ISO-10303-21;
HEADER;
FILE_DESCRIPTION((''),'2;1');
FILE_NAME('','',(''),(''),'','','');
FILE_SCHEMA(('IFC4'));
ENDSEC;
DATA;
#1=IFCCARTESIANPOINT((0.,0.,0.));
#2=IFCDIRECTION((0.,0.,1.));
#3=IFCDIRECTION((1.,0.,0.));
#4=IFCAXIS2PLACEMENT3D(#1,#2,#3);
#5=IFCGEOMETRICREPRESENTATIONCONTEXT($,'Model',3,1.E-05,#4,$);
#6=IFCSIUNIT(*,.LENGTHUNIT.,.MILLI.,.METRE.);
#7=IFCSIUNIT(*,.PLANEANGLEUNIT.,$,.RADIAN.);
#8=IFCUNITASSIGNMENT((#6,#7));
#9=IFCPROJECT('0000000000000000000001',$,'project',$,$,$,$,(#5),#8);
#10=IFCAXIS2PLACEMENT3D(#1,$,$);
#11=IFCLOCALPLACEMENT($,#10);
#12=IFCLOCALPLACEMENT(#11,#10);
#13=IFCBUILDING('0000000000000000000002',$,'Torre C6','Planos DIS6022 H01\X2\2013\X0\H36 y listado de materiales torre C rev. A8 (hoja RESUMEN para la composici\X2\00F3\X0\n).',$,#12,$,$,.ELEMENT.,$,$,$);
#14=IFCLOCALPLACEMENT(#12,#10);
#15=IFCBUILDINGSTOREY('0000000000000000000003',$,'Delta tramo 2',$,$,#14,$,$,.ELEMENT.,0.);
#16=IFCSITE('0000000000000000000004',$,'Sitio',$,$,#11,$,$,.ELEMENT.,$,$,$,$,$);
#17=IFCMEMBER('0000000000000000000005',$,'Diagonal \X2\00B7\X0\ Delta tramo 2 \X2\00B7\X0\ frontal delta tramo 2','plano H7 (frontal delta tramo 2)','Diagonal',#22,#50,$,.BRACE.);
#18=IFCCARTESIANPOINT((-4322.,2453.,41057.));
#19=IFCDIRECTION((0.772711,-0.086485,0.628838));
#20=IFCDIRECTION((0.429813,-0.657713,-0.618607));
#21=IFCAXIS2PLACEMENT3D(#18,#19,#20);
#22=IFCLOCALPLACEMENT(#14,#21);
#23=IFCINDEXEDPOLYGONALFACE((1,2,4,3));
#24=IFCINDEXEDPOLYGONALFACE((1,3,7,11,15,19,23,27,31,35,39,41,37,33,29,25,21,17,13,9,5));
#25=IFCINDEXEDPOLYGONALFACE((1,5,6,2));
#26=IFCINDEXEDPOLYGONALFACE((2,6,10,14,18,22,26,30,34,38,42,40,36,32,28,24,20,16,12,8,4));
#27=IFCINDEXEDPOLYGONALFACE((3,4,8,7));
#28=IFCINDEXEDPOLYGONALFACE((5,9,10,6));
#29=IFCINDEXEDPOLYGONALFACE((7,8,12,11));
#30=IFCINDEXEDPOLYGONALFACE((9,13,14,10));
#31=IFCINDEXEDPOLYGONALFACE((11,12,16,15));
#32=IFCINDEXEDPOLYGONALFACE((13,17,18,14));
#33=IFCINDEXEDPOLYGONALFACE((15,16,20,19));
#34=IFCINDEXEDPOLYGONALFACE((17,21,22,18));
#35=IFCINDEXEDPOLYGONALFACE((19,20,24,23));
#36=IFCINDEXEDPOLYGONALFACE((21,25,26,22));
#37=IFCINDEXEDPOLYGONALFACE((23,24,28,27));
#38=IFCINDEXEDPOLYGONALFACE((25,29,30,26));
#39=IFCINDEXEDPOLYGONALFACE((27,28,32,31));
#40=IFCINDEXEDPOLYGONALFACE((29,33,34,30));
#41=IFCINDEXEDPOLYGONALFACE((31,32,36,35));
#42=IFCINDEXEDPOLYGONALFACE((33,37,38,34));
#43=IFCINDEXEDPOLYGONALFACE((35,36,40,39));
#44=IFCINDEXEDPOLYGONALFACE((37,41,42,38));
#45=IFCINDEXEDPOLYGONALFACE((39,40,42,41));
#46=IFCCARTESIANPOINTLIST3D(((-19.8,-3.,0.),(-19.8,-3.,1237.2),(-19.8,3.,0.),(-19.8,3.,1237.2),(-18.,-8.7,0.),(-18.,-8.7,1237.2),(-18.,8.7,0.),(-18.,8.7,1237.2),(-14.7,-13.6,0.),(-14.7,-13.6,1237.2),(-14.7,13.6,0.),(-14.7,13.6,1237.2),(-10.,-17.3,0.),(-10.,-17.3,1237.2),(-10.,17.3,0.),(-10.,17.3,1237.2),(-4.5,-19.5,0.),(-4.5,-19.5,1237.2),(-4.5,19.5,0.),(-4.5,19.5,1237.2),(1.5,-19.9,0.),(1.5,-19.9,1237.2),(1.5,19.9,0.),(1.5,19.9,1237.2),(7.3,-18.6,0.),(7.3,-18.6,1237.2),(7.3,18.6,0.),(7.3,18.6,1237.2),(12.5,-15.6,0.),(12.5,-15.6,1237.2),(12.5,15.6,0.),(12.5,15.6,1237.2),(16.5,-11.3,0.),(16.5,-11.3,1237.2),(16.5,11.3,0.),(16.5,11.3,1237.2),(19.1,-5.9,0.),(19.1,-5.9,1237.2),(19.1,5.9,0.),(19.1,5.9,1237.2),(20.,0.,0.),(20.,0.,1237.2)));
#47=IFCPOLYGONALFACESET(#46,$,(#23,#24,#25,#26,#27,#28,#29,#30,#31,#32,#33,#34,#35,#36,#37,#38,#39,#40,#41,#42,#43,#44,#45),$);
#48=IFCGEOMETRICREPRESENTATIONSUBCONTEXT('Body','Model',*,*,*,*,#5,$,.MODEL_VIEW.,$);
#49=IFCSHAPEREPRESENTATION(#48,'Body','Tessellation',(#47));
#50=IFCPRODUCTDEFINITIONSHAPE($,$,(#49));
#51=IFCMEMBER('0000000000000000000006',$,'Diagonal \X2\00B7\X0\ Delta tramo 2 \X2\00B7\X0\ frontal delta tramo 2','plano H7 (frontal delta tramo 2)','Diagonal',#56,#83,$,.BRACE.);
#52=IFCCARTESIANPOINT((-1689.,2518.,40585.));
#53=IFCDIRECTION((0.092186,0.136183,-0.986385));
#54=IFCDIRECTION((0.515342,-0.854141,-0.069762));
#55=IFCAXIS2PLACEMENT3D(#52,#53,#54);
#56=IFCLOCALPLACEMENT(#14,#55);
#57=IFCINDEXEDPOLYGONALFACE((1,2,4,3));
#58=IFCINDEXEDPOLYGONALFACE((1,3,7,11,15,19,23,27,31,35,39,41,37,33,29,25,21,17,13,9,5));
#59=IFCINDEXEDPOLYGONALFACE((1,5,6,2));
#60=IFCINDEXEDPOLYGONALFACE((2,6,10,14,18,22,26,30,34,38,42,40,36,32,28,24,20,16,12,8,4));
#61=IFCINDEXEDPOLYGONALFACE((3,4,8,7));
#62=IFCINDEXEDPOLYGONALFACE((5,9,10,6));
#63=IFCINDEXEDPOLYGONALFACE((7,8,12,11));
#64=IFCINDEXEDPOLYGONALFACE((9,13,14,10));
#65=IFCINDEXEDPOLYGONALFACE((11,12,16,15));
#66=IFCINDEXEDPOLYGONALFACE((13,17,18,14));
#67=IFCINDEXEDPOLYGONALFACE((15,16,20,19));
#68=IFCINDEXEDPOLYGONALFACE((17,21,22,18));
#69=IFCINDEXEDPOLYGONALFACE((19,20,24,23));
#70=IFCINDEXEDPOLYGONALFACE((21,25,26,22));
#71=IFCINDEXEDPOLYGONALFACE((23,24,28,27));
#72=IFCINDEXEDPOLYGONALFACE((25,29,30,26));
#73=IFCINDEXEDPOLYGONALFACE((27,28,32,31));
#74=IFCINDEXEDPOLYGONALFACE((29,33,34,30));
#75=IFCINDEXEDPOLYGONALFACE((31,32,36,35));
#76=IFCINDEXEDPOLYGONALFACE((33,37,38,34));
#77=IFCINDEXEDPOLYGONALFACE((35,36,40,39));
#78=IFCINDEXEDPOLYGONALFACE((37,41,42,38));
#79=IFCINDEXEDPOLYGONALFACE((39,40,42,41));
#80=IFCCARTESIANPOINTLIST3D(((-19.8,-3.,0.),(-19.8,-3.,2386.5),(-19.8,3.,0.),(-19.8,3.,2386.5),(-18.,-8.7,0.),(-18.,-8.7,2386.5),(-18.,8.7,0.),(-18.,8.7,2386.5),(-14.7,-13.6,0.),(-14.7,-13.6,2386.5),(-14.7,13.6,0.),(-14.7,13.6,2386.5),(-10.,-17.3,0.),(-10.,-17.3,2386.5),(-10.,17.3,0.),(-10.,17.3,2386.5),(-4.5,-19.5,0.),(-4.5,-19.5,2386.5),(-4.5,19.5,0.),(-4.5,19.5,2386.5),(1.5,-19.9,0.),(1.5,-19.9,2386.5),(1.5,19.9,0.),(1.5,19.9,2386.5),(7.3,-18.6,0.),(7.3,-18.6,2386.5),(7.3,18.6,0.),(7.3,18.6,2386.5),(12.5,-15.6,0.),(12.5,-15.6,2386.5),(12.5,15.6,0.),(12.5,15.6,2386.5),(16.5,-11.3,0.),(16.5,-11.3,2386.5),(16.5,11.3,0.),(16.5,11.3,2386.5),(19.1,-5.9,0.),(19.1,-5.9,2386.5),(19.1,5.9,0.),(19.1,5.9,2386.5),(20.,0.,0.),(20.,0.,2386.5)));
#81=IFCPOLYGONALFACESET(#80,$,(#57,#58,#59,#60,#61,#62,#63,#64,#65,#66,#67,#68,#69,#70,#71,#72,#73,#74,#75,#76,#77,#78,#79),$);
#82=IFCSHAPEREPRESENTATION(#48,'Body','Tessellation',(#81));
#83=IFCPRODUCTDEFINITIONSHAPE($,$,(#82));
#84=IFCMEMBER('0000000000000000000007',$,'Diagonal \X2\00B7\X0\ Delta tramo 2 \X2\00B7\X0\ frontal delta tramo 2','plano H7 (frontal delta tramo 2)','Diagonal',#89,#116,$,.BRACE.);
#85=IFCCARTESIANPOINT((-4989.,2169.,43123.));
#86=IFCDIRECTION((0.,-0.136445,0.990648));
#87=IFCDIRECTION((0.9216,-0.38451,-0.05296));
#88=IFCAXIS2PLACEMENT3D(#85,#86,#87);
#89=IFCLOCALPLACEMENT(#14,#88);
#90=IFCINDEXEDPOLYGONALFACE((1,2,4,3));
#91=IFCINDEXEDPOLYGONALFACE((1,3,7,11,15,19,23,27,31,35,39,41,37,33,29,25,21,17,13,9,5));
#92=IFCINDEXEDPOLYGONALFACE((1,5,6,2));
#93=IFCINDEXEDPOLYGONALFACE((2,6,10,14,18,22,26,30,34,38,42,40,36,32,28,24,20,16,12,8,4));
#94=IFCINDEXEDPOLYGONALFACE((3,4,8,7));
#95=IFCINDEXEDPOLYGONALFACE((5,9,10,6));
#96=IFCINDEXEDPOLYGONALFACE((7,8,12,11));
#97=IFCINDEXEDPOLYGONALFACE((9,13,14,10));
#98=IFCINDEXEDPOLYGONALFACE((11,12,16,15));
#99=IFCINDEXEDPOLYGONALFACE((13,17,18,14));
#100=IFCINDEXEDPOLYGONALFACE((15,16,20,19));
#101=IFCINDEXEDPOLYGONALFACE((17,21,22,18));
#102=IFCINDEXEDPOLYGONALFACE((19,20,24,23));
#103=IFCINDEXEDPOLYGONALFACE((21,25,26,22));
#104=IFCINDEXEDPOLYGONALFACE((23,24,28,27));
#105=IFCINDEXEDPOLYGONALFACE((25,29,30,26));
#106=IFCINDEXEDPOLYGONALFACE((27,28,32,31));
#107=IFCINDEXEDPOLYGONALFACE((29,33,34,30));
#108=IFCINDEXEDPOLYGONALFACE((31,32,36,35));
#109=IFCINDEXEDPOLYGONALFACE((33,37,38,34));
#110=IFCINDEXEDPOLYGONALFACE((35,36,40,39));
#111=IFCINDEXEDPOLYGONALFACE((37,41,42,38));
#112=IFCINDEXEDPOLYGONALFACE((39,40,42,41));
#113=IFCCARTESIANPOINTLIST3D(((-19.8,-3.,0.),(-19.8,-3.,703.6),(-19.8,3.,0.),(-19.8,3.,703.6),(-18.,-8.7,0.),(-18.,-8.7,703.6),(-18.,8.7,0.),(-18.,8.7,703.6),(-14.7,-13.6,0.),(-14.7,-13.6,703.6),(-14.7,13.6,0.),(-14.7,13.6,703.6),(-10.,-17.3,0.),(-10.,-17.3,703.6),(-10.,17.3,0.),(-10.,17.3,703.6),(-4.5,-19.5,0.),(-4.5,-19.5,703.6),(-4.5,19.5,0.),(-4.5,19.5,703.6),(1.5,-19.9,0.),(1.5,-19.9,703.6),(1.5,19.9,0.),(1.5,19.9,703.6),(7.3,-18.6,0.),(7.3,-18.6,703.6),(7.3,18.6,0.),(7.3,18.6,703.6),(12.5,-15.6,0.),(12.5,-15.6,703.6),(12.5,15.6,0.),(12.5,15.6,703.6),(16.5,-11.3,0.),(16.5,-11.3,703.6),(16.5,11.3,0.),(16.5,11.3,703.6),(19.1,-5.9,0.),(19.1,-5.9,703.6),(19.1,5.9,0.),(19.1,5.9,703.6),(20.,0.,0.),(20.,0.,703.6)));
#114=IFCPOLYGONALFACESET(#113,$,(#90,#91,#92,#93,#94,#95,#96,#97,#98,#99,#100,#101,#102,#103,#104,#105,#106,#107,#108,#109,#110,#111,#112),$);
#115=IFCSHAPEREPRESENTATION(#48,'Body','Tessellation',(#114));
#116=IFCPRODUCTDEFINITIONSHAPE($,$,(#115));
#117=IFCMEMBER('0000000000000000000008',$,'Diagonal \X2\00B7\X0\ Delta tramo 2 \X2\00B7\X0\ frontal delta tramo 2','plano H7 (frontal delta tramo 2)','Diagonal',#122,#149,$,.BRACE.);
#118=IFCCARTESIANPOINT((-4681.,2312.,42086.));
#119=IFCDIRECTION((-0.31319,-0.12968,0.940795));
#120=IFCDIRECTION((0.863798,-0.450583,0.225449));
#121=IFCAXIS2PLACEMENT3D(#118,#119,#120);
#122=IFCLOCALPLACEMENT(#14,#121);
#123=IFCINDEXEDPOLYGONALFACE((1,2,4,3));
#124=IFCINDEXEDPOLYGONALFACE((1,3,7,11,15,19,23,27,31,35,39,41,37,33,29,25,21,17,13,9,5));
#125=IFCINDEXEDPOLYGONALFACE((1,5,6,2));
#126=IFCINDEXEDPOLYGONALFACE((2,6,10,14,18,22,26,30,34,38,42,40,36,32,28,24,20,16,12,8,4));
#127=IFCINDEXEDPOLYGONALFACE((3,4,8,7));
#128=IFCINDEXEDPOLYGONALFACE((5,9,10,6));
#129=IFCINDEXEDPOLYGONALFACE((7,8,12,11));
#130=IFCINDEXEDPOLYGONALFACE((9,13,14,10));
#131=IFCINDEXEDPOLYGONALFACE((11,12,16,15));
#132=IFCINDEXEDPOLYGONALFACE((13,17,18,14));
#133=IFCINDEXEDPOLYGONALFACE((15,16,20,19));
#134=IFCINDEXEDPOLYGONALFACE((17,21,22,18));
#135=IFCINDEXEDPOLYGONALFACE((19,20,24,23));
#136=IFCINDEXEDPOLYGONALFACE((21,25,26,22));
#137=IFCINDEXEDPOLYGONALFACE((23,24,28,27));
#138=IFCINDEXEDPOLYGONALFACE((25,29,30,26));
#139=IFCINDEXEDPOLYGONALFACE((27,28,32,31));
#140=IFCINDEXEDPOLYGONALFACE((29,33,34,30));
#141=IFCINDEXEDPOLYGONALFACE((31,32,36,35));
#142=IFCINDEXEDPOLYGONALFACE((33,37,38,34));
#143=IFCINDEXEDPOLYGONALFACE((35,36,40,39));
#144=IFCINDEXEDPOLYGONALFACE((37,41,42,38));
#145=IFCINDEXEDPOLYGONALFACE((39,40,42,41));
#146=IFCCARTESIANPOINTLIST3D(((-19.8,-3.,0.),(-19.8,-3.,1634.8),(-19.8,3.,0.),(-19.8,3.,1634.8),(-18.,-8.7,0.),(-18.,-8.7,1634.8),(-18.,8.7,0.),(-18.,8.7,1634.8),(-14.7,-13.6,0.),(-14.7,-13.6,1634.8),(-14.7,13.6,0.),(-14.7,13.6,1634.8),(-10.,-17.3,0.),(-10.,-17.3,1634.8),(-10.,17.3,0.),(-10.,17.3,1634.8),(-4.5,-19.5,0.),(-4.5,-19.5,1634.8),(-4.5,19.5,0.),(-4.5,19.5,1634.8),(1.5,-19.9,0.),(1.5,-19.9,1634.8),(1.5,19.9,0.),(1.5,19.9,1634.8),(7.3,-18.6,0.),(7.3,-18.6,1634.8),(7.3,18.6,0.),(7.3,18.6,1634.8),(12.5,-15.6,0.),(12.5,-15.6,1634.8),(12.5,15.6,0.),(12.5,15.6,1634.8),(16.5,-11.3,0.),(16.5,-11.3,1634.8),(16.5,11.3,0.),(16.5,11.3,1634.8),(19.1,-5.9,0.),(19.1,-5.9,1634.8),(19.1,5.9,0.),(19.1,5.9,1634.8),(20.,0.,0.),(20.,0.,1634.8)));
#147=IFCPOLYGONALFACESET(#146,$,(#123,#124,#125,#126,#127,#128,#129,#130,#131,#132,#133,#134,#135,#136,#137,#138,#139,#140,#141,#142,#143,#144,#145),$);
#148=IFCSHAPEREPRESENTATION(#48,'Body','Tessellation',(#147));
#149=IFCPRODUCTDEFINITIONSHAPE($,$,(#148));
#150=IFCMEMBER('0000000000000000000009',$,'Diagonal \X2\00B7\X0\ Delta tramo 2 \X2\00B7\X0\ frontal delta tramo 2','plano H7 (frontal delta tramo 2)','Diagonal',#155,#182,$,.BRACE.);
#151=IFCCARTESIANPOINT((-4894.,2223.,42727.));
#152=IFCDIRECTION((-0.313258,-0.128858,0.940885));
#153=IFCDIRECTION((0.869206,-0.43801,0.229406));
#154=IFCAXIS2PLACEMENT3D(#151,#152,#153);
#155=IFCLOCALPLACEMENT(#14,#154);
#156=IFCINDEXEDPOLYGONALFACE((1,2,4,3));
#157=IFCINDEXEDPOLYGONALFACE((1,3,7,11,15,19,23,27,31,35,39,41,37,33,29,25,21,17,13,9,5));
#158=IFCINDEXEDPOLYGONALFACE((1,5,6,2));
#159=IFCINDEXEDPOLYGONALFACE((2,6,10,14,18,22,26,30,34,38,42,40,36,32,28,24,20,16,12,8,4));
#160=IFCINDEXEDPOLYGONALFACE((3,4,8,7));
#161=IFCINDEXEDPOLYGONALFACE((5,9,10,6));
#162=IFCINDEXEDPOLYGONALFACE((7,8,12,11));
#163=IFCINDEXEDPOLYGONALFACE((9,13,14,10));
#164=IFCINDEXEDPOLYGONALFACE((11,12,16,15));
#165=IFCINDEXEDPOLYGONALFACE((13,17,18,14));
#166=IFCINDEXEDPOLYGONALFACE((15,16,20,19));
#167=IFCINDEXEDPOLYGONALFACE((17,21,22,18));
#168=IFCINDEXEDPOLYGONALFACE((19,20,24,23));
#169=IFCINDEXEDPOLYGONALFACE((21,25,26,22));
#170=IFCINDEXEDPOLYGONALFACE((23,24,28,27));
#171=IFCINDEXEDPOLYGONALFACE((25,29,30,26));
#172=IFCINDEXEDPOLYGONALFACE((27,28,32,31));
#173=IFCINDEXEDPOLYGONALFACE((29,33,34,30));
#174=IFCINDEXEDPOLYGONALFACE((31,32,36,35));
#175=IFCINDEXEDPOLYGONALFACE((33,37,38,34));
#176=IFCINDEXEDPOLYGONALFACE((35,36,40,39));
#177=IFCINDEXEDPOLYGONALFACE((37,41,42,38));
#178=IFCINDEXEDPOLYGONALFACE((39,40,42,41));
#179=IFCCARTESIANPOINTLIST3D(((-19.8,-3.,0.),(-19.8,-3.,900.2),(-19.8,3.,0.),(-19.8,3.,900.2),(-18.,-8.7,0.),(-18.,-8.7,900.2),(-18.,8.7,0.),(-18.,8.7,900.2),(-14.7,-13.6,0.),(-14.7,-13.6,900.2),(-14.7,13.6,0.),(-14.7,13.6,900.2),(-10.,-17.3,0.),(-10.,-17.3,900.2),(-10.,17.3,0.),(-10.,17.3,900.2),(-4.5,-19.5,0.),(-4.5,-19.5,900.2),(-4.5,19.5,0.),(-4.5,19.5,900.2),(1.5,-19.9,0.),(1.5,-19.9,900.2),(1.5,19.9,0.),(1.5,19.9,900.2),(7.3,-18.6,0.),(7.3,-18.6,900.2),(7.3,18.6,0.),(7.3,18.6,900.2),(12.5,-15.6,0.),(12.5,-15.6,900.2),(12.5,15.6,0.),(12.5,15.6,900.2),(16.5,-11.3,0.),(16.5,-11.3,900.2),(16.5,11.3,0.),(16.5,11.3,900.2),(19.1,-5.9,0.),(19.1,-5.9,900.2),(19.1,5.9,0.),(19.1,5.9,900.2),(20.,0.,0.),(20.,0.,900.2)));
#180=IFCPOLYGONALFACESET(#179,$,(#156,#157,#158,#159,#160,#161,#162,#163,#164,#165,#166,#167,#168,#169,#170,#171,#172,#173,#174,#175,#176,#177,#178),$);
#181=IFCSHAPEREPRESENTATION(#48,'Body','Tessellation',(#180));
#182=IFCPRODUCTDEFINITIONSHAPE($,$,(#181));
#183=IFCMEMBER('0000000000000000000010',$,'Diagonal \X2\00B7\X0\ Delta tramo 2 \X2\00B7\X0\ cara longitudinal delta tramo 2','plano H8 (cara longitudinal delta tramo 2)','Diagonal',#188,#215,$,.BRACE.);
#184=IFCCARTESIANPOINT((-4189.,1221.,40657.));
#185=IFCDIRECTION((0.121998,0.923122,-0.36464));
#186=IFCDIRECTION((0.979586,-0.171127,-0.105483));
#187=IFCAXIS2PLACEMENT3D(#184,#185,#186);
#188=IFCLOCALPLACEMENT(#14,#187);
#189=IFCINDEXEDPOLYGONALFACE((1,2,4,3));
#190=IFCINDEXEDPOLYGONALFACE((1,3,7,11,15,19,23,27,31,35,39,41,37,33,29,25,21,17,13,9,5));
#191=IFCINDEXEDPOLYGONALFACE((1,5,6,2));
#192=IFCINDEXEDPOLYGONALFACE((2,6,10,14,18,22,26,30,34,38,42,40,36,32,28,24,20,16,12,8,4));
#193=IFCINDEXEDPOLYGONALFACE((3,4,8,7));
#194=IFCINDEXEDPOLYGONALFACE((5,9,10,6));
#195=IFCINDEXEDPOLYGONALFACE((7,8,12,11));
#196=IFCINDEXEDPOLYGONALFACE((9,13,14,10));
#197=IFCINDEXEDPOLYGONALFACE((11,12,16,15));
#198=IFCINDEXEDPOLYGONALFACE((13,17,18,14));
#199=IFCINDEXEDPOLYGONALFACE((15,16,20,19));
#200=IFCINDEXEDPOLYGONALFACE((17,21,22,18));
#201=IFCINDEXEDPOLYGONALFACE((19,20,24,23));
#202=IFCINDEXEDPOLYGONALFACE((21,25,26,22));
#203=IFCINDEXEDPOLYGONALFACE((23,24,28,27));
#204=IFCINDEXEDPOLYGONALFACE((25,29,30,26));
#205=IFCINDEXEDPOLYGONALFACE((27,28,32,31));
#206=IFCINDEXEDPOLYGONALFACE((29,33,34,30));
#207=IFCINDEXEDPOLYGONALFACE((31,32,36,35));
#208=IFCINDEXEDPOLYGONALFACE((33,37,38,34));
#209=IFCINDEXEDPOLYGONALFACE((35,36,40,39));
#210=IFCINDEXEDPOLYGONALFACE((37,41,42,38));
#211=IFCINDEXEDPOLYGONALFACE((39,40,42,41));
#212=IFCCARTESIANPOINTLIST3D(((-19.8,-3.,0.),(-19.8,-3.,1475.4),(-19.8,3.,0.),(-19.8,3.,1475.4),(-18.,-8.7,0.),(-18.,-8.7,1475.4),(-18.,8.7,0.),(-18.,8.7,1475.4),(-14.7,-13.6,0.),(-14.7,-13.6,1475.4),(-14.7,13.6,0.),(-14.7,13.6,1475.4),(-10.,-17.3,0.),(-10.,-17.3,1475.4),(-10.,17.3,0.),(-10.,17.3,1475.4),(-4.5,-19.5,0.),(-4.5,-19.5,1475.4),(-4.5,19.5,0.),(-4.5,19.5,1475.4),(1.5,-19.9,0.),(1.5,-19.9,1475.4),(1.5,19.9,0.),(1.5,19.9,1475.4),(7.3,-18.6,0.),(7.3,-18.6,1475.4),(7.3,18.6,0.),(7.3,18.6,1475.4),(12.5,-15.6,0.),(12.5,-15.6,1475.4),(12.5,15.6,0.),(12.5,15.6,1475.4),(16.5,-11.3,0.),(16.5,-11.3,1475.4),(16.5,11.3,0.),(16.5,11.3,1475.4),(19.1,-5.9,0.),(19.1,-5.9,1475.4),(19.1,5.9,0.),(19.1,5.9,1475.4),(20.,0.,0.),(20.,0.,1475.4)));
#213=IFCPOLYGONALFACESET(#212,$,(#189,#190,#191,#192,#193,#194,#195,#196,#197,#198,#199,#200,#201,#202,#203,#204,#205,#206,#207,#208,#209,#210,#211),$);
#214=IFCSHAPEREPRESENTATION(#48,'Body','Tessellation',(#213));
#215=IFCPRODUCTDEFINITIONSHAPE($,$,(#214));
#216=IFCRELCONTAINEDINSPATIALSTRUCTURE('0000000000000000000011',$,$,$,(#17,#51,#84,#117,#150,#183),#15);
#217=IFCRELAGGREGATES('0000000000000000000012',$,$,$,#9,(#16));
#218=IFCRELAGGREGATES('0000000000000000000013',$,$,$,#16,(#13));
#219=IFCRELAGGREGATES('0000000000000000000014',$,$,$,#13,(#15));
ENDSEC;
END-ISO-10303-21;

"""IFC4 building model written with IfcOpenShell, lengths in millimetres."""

from ifc_helpers import new_model, si_unit, frame, origin, origin_with_axes, place, context, subcontext, project, spatial, circle, extrude, element, save


model = new_model("IFC4")

# Units and contexts
model_context = context("Model", 3, precision=1e-05, world=origin_with_axes())
body_context = subcontext(model_context, "Body", "Model", "MODEL_VIEW")
ifc_project = project(units=[si_unit("LENGTHUNIT", "METRE", prefix="MILLI"), si_unit("PLANEANGLEUNIT", "RADIAN")], contexts=[model_context])

# Site, building, storey
site_placement = place(None, origin())
site = spatial("IfcSite", under=ifc_project, at=site_placement, Name="Sitio", CompositionType="ELEMENT")
building_placement = place(site_placement, origin())
building = spatial("IfcBuilding", under=site, at=building_placement, Name="Torre C6", Description="Planos DIS6022 H01–H36 y listado de materiales torre C rev. A8 (hoja RESUMEN para la composición).", CompositionType="ELEMENT")
storey_placement = place(building_placement, origin())
storey = spatial("IfcBuildingStorey", under=building, at=storey_placement, Name="Delta tramo 2", CompositionType="ELEMENT", Elevation=0.0)

# Members
member_1_placement = place(storey_placement, frame((-4322.0, 2453.0, 41057.0), z_axis=(0.772711, -0.086485, 0.628838), x_axis=(0.429813, -0.657713, -0.618607)))
element("IfcMember", 1, at=member_1_placement, inside=storey, Name="Diagonal · Delta tramo 2 · frontal delta tramo 2", Description="plano H7 (frontal delta tramo 2)", ObjectType="Diagonal", PredefinedType="BRACE", context=body_context, shape_type="SweptSolid", body=[
    extrude(circle(Radius=20.0), None, (0.0, 0.0, 1.0), 1237.2),
])
member_2_placement = place(storey_placement, frame((-1689.0, 2518.0, 40585.0), z_axis=(0.092186, 0.136183, -0.986385), x_axis=(0.515342, -0.854141, -0.069762)))
element("IfcMember", 2, at=member_2_placement, inside=storey, Name="Diagonal · Delta tramo 2 · frontal delta tramo 2", Description="plano H7 (frontal delta tramo 2)", ObjectType="Diagonal", PredefinedType="BRACE", context=body_context, shape_type="SweptSolid", body=[
    extrude(circle(Radius=20.0), None, (0.0, 0.0, 1.0), 2386.5),
])
member_3_placement = place(storey_placement, frame((-4989.0, 2169.0, 43123.0), z_axis=(0.0, -0.136445, 0.990648), x_axis=(0.9216, -0.38451, -0.05296)))
element("IfcMember", 3, at=member_3_placement, inside=storey, Name="Diagonal · Delta tramo 2 · frontal delta tramo 2", Description="plano H7 (frontal delta tramo 2)", ObjectType="Diagonal", PredefinedType="BRACE", context=body_context, shape_type="SweptSolid", body=[
    extrude(circle(Radius=20.0), None, (0.0, 0.0, 1.0), 703.6),
])
member_4_placement = place(storey_placement, frame((-4681.0, 2312.0, 42086.0), z_axis=(-0.31319, -0.12968, 0.940795), x_axis=(0.863798, -0.450583, 0.225449)))
element("IfcMember", 4, at=member_4_placement, inside=storey, Name="Diagonal · Delta tramo 2 · frontal delta tramo 2", Description="plano H7 (frontal delta tramo 2)", ObjectType="Diagonal", PredefinedType="BRACE", context=body_context, shape_type="SweptSolid", body=[
    extrude(circle(Radius=20.0), None, (0.0, 0.0, 1.0), 1634.8),
])
member_5_placement = place(storey_placement, frame((-4894.0, 2223.0, 42727.0), z_axis=(-0.313258, -0.128858, 0.940885), x_axis=(0.869206, -0.43801, 0.229406)))
element("IfcMember", 5, at=member_5_placement, inside=storey, Name="Diagonal · Delta tramo 2 · frontal delta tramo 2", Description="plano H7 (frontal delta tramo 2)", ObjectType="Diagonal", PredefinedType="BRACE", context=body_context, shape_type="SweptSolid", body=[
    extrude(circle(Radius=20.0), None, (0.0, 0.0, 1.0), 900.2),
])
member_6_placement = place(storey_placement, frame((-4189.0, 1221.0, 40657.0), z_axis=(0.121998, 0.923122, -0.36464), x_axis=(0.979586, -0.171127, -0.105483)))
element("IfcMember", 6, at=member_6_placement, inside=storey, Name="Diagonal · Delta tramo 2 · cara longitudinal delta tramo 2", Description="plano H8 (cara longitudinal delta tramo 2)", ObjectType="Diagonal", PredefinedType="BRACE", context=body_context, shape_type="SweptSolid", body=[
    extrude(circle(Radius=20.0), None, (0.0, 0.0, 1.0), 1475.4),
])

save(model, "model.ifc")
